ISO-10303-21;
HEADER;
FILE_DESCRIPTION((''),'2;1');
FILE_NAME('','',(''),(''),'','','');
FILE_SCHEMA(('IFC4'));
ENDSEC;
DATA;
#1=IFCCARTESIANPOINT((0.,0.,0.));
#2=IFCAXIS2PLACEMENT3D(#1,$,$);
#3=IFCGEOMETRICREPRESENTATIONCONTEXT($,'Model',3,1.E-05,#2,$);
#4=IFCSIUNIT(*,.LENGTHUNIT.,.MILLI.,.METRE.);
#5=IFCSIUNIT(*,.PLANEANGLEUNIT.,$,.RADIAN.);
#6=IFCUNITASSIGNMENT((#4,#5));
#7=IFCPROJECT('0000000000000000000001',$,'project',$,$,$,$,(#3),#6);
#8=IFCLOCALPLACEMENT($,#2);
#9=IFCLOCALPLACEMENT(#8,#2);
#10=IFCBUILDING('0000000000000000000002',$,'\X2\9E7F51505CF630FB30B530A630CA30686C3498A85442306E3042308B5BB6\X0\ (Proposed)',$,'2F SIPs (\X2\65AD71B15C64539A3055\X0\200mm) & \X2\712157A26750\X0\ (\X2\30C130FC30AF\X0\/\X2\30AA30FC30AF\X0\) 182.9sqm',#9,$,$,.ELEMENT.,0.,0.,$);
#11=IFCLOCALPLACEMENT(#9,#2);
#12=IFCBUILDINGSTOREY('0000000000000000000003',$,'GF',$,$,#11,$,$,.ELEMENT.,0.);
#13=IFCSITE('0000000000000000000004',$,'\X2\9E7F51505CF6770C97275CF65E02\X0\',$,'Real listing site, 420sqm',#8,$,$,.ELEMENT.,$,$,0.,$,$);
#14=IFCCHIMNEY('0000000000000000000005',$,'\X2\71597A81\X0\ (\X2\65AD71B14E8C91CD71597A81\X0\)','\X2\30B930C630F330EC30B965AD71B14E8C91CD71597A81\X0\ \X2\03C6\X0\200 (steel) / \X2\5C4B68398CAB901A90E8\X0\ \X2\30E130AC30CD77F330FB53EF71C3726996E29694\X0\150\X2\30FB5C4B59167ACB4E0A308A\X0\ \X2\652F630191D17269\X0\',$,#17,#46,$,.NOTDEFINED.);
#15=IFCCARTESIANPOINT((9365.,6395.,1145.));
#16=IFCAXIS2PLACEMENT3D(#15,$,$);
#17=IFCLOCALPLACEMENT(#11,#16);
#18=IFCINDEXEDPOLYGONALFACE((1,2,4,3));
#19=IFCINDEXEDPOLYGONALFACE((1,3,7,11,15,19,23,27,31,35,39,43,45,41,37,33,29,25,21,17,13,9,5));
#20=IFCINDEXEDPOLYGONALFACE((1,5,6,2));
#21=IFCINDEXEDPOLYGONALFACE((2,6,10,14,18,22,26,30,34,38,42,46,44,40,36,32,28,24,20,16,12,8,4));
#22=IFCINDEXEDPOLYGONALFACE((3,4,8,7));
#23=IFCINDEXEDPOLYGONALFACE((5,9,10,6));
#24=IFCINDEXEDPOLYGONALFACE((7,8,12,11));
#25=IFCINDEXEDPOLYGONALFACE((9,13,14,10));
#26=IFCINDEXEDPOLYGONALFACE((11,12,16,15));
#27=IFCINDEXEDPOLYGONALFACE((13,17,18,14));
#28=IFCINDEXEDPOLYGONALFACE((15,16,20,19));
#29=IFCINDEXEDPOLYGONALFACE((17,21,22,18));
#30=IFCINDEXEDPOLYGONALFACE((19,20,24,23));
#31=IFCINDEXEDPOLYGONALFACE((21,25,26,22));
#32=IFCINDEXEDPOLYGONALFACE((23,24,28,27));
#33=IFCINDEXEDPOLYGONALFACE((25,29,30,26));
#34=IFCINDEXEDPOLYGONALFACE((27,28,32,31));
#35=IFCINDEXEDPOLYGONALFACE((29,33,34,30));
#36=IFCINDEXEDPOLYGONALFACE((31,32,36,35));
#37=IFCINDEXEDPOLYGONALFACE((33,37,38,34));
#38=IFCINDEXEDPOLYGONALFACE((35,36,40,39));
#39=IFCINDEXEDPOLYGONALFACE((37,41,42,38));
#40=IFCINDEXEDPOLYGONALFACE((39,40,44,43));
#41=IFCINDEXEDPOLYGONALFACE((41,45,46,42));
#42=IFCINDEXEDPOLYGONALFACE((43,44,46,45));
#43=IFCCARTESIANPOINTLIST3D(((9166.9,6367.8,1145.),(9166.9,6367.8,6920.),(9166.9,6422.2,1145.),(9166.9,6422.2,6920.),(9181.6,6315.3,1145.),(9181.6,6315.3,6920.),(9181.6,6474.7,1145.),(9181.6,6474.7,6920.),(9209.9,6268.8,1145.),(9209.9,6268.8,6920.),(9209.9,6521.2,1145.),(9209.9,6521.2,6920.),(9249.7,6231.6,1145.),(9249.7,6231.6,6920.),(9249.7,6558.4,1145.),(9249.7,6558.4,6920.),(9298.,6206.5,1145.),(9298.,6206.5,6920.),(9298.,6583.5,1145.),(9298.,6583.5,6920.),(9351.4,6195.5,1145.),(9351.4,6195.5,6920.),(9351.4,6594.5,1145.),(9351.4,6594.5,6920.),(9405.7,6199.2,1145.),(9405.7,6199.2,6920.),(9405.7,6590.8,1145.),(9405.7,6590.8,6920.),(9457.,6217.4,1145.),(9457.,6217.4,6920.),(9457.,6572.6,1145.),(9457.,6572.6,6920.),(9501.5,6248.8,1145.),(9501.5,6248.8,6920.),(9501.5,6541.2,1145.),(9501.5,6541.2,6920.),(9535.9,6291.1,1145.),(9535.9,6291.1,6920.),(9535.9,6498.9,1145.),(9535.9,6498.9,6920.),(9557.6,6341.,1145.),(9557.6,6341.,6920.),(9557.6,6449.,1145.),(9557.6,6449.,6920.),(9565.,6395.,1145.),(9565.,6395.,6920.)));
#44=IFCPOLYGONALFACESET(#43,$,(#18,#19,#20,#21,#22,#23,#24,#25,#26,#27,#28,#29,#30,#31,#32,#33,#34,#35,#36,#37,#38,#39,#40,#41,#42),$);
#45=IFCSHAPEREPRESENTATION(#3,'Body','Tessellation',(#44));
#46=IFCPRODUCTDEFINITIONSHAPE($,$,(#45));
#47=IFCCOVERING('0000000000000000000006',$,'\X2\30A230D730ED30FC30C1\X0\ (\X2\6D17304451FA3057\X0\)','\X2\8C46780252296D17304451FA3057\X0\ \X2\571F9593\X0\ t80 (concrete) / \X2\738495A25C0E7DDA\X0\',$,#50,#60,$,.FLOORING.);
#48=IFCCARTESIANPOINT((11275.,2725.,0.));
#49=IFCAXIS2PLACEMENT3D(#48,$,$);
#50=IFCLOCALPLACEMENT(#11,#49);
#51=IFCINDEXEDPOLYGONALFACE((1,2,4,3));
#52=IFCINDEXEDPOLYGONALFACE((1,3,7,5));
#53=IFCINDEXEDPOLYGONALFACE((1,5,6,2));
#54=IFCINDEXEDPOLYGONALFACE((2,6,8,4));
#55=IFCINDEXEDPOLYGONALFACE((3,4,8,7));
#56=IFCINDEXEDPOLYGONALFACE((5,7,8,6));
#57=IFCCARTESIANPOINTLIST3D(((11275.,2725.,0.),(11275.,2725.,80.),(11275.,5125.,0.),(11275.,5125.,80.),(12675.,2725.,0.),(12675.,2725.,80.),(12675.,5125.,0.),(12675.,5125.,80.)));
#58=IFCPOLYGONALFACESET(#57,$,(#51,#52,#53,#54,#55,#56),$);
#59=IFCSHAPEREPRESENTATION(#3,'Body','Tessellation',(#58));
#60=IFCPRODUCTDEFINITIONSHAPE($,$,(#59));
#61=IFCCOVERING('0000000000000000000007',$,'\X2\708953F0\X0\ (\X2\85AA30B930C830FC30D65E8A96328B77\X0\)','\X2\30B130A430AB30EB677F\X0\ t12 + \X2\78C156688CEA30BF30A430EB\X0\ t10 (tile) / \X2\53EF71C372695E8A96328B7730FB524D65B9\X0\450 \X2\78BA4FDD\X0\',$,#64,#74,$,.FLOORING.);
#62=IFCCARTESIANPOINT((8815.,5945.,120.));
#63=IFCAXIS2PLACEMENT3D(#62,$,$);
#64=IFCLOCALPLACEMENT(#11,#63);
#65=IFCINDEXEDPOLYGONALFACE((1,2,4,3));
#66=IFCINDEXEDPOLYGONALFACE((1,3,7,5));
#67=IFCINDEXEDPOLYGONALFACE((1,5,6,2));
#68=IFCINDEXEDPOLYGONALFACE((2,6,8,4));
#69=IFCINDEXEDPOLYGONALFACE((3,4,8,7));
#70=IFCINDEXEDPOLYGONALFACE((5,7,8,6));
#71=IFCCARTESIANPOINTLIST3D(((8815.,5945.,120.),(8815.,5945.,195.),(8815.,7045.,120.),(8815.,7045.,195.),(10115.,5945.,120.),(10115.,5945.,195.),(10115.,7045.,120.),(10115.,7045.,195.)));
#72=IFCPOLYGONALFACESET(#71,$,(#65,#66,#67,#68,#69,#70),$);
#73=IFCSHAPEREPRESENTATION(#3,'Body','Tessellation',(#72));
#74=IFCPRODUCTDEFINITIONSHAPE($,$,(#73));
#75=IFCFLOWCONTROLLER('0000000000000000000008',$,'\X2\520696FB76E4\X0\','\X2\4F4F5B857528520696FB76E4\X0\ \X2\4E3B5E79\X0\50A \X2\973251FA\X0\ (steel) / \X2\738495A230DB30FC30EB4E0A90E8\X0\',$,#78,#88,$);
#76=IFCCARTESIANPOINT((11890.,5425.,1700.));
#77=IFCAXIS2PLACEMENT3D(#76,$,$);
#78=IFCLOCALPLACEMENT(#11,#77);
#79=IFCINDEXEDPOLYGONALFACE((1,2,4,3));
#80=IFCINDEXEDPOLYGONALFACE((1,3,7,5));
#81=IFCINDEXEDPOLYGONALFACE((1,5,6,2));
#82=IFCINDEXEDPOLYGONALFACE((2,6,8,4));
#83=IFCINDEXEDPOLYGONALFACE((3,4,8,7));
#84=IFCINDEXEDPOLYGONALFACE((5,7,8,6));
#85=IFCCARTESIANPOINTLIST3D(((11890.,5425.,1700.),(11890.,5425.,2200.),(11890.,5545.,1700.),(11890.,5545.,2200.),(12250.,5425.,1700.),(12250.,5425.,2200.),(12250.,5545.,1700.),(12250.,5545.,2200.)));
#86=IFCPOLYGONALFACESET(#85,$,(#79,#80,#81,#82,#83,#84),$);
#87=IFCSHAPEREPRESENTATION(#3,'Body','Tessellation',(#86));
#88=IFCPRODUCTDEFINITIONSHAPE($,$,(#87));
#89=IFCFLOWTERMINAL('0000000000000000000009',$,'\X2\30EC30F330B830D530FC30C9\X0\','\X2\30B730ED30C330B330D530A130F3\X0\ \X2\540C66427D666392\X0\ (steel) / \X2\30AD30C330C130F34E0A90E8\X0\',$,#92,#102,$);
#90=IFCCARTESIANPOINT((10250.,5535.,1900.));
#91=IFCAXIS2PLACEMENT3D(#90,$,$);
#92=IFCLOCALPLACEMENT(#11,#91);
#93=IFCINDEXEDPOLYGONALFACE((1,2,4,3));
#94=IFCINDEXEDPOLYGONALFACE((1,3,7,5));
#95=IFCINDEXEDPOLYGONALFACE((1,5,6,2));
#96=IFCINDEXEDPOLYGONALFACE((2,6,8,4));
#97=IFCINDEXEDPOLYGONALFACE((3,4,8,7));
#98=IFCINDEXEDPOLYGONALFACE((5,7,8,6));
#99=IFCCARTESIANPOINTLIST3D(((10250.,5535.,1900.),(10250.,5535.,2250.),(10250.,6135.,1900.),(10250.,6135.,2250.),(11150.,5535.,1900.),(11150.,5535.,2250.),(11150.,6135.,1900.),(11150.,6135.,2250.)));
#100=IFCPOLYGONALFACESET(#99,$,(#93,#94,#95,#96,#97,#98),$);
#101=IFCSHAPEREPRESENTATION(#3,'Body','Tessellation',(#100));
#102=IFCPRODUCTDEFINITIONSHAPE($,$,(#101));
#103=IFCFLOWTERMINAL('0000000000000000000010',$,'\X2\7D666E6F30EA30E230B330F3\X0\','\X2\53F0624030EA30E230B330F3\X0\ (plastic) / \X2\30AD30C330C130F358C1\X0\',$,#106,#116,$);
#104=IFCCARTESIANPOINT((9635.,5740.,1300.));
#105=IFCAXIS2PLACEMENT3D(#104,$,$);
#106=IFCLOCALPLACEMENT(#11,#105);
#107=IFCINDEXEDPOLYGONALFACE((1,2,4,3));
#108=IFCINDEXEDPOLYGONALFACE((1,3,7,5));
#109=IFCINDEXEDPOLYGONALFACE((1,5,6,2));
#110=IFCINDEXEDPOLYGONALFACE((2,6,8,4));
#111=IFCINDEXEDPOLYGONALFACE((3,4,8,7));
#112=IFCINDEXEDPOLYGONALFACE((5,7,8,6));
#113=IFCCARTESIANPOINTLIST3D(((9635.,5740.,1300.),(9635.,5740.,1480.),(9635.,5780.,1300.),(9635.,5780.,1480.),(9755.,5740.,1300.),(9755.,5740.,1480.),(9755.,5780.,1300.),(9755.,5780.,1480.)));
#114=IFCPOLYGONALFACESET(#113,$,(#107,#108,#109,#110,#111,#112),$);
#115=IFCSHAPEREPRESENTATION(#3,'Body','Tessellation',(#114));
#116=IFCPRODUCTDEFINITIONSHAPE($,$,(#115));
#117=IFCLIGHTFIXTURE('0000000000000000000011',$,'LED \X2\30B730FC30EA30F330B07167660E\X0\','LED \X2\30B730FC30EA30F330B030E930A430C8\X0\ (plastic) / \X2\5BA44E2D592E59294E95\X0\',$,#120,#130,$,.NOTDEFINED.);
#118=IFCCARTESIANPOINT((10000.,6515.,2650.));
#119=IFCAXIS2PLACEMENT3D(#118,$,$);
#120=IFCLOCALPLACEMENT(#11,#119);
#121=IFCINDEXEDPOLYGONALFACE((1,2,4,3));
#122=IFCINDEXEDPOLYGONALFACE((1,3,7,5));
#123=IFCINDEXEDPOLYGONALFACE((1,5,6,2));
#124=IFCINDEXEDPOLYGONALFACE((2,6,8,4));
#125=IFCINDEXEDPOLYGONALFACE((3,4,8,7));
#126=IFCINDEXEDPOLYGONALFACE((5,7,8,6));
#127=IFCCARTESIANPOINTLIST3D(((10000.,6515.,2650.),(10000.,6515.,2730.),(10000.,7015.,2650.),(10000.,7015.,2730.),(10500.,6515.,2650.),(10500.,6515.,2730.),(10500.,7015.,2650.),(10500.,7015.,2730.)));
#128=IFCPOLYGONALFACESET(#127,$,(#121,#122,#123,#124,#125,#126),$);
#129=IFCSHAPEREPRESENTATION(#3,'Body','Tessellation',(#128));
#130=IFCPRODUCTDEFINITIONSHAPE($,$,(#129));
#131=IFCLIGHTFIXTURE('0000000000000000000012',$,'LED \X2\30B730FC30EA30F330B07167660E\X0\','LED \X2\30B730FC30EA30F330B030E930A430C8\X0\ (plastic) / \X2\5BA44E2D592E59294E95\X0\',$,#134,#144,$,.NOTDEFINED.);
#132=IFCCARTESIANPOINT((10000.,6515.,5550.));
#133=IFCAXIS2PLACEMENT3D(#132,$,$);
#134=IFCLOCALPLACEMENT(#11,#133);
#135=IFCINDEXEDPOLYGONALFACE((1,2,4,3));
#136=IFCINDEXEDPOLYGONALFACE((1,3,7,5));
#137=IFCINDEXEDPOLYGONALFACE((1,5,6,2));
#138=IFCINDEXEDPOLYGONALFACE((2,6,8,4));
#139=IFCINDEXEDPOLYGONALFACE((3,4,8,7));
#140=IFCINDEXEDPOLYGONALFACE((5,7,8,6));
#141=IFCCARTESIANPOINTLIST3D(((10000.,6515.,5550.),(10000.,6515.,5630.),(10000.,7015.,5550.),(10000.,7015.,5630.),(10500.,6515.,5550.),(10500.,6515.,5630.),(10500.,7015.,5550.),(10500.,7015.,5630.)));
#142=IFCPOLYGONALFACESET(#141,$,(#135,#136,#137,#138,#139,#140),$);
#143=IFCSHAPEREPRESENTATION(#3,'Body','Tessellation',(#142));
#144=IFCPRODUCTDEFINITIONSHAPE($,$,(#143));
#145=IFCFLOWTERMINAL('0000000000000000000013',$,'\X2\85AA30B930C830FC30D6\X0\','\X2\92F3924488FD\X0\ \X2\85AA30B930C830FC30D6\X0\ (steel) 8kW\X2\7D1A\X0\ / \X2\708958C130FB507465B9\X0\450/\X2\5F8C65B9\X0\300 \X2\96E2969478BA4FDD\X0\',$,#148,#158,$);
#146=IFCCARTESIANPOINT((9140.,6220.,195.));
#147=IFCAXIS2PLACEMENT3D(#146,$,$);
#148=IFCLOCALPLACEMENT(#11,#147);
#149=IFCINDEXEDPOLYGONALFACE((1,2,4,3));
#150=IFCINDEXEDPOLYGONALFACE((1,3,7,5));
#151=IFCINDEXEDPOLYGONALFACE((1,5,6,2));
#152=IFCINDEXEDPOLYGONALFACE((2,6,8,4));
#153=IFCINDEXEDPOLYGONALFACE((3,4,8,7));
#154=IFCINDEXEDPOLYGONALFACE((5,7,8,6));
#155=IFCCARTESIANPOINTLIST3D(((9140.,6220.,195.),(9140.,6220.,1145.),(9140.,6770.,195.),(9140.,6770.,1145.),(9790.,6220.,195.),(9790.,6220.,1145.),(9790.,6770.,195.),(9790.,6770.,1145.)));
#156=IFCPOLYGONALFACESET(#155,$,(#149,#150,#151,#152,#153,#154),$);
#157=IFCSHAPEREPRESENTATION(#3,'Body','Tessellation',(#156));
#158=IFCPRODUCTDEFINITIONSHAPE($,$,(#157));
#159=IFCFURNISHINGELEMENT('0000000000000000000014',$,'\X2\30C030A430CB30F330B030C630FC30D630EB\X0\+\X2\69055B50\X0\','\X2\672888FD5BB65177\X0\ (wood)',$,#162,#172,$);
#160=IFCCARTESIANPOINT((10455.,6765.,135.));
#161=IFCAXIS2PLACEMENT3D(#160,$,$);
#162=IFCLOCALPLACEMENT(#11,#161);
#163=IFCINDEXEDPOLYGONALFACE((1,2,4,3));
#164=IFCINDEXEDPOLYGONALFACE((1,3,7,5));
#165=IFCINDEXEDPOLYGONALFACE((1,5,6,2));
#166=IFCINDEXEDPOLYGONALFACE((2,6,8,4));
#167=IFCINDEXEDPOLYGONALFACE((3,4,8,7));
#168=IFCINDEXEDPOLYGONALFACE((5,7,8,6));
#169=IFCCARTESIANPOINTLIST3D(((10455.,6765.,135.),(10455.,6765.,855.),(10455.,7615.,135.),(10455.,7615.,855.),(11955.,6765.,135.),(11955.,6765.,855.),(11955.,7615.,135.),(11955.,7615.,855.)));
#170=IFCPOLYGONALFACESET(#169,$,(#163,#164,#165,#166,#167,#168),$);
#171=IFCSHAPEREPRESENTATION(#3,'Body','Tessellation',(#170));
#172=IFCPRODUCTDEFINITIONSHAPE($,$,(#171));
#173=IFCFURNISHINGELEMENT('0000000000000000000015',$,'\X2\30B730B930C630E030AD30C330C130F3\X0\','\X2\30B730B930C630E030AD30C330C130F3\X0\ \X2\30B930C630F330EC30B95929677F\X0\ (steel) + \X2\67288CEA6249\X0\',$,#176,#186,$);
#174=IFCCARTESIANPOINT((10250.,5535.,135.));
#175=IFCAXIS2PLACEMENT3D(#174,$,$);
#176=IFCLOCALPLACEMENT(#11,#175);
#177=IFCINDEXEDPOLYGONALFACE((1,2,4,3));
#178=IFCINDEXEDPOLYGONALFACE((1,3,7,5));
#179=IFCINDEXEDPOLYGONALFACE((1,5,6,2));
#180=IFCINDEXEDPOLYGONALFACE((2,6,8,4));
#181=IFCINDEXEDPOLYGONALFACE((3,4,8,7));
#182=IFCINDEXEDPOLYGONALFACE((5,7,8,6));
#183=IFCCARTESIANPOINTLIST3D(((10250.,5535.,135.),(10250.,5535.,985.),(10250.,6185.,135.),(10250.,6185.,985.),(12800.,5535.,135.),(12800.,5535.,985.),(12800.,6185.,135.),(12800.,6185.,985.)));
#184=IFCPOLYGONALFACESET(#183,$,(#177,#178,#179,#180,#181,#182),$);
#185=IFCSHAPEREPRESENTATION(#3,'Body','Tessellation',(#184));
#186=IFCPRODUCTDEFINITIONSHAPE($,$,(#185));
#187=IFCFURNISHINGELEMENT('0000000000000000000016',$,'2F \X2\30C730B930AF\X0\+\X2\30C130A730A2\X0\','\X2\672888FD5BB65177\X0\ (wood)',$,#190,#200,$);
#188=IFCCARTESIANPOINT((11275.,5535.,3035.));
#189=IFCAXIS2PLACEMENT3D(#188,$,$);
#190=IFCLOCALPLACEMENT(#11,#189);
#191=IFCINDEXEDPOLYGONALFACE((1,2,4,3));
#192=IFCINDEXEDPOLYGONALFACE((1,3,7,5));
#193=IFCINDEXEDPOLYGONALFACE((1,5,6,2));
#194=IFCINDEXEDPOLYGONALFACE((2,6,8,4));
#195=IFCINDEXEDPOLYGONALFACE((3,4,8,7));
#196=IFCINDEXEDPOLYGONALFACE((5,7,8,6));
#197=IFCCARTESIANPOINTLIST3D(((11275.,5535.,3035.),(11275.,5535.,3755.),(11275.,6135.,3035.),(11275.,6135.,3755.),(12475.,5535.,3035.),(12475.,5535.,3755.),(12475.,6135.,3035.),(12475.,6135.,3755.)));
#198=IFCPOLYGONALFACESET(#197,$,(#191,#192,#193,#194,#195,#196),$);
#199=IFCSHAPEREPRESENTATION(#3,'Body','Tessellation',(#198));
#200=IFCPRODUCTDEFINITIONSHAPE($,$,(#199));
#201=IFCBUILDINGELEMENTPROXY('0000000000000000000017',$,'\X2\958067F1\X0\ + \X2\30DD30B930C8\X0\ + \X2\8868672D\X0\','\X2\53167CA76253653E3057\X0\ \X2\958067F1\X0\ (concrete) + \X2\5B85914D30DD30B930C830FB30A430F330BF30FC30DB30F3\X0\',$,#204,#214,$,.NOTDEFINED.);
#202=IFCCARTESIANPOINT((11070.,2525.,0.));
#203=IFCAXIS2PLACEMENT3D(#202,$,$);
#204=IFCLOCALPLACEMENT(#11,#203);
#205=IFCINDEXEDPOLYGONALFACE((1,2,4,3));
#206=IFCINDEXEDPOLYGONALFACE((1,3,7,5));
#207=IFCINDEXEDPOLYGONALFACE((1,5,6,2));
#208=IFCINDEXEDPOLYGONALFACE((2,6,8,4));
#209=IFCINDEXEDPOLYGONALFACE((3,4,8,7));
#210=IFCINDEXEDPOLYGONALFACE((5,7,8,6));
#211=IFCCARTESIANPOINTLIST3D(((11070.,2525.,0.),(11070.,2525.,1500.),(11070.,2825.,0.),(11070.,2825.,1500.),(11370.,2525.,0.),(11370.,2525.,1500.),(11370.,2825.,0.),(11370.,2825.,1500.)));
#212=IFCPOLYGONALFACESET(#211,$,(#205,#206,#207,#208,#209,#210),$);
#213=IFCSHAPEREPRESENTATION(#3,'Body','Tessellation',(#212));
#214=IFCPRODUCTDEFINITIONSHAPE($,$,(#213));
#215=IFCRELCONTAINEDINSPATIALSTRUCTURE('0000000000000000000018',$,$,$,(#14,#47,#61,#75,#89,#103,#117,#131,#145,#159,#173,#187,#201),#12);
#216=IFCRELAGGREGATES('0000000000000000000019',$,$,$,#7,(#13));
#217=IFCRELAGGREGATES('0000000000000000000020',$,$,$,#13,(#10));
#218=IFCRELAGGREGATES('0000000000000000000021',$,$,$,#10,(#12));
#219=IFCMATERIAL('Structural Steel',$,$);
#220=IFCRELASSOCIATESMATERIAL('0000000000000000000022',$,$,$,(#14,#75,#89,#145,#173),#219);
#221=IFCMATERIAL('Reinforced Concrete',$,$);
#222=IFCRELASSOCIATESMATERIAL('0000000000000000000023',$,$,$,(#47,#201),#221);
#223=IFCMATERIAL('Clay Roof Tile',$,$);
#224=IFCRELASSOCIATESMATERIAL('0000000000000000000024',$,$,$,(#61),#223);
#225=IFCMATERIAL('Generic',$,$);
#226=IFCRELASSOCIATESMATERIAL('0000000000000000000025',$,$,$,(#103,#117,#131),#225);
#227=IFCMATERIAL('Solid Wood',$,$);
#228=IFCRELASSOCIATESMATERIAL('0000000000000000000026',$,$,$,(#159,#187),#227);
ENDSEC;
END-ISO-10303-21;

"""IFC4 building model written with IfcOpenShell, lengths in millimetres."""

from ifc_helpers import new_model, si_unit, frame, frame_2d, origin, origin_2d, place, context, project, spatial, rectangle, circle, extrude, material, element, save


model = new_model("IFC4")

# Units and contexts
model_context = context("Model", 3, precision=1e-05, world=origin())
ifc_project = project(units=[si_unit("LENGTHUNIT", "METRE", prefix="MILLI"), si_unit("PLANEANGLEUNIT", "RADIAN")], contexts=[model_context])

# Site, building, storey
site_placement = place(None, origin())
site = spatial("IfcSite", under=ifc_project, at=site_placement, Name="鹿児島県霧島市", ObjectType="Real listing site, 420sqm", CompositionType="ELEMENT", RefElevation=0.0)
building_placement = place(site_placement, origin())
building = spatial("IfcBuilding", under=site, at=building_placement, Name="鹿児島・サウナと水風呂のある家 (Proposed)", ObjectType="2F SIPs (断熱層厚さ200mm) & 無垢材 (チーク/オーク) 182.9sqm", CompositionType="ELEMENT", ElevationOfRefHeight=0.0, ElevationOfTerrain=0.0)
storey_placement = place(building_placement, origin())
storey = spatial("IfcBuildingStorey", under=building, at=storey_placement, Name="GF", CompositionType="ELEMENT", Elevation=0.0)

# Shared definitions
ifc_material_1 = material(Name="Solid Wood")

# Shared definitions
ifc_material_2 = material(Name="Structural Steel")

# Chimney
chimney_placement = place(storey_placement, frame((9365.0, 6395.0, 1145.0)))
element("IfcChimney", 1, at=chimney_placement, inside=storey, material=ifc_material_2, Name="煙突 (断熱二重煙突)", Description="ステンレス断熱二重煙突 φ200 (steel) / 屋根貫通部 メガネ石・可燃物離隔150・屋外立上り 支持金物", PredefinedType="NOTDEFINED", context=model_context, shape_type="SweptSolid", body=[
    extrude(circle(Radius=200.0, at=origin_2d()), frame((9365.0, 6395.0, 1145.0)), (0.0, 0.0, 1.0), 5775.0),
])

# Coverings
ifc_material_3 = material(Name="Reinforced Concrete")
covering_1_placement = place(storey_placement, frame((11275.0, 2725.0, 0.0)))
element("IfcCovering", 2, at=covering_1_placement, inside=storey, material=ifc_material_3, Name="アプローチ (洗い出し)", Description="豆砂利洗い出し 土間 t80 (concrete) / 玄関導線", PredefinedType="FLOORING", context=model_context, shape_type="SweptSolid", body=[
    extrude(rectangle(XDim=1400.0, YDim=2400.0, at=frame_2d((700.0, 1200.0))), frame((11275.0, 2725.0, 0.0)), (0.0, 0.0, 1.0), 80.0),
])
ifc_material_4 = material(Name="Clay Roof Tile")
covering_2_placement = place(storey_placement, frame((8815.0, 5945.0, 120.0)))
element("IfcCovering", 3, at=covering_2_placement, inside=storey, material=ifc_material_4, Name="炉台 (薪ストーブ床防護)", Description="ケイカル板 t12 + 磁器質タイル t10 (tile) / 可燃物床防護・前方450 確保", PredefinedType="FLOORING", context=model_context, shape_type="SweptSolid", body=[
    extrude(rectangle(XDim=1300.0, YDim=1100.0, at=frame_2d((650.0, 550.0))), frame((8815.0, 5945.0, 120.0)), (0.0, 0.0, 1.0), 75.0),
])

# Flow controller
flow_controller_placement = place(storey_placement, frame((11890.0, 5425.0, 1700.0)))
element("IfcFlowController", 4, at=flow_controller_placement, inside=storey, material=ifc_material_2, Name="分電盤", Description="住宅用分電盤 主幹50A 露出 (steel) / 玄関ホール上部", context=model_context, shape_type="SweptSolid", body=[
    extrude(rectangle(XDim=360.0, YDim=120.0, at=frame_2d((180.0, 60.0))), frame((11890.0, 5425.0, 1700.0)), (0.0, 0.0, 1.0), 500.0),
])

# Flow terminals
flow_terminal_1_placement = place(storey_placement, frame((10250.0, 5535.0, 1900.0)))
element("IfcFlowTerminal", 5, at=flow_terminal_1_placement, inside=storey, material=ifc_material_2, Name="レンジフード", Description="シロッコファン 同時給排 (steel) / キッチン上部", context=model_context, shape_type="SweptSolid", body=[
    extrude(rectangle(XDim=900.0, YDim=600.0, at=frame_2d((450.0, 300.0))), frame((10250.0, 5535.0, 1900.0)), (0.0, 0.0, 1.0), 350.0),
])
ifc_material_5 = material(Name="Generic")
flow_terminal_2_placement = place(storey_placement, frame((9635.0, 5740.0, 1300.0)))
element("IfcFlowTerminal", 6, at=flow_terminal_2_placement, inside=storey, material=ifc_material_5, Name="給湯リモコン", Description="台所リモコン (plastic) / キッチン壁", context=model_context, shape_type="SweptSolid", body=[
    extrude(rectangle(XDim=120.0, YDim=40.0, at=frame_2d((60.0, 20.0))), frame((9635.0, 5740.0, 1300.0)), (0.0, 0.0, 1.0), 180.0),
])

# Light fixtures
light_fixture_1_placement = place(storey_placement, frame((10000.0, 6515.0, 2650.0)))
element("IfcLightFixture", 7, at=light_fixture_1_placement, inside=storey, material=ifc_material_5, Name="LED シーリング照明", Description="LED シーリングライト (plastic) / 室中央天井", PredefinedType="NOTDEFINED", context=model_context, shape_type="SweptSolid", body=[
    extrude(rectangle(XDim=500.0, YDim=500.0, at=frame_2d((250.0, 250.0))), frame((10000.0, 6515.0, 2650.0)), (0.0, 0.0, 1.0), 80.0),
])
light_fixture_2_placement = place(storey_placement, frame((10000.0, 6515.0, 5550.0)))
element("IfcLightFixture", 8, at=light_fixture_2_placement, inside=storey, material=ifc_material_5, Name="LED シーリング照明", Description="LED シーリングライト (plastic) / 室中央天井", PredefinedType="NOTDEFINED", context=model_context, shape_type="SweptSolid", body=[
    extrude(rectangle(XDim=500.0, YDim=500.0, at=frame_2d((250.0, 250.0))), frame((10000.0, 6515.0, 5550.0)), (0.0, 0.0, 1.0), 80.0),
])

# Flow terminal
flow_terminal_3_placement = place(storey_placement, frame((9140.0, 6220.0, 195.0)))
element("IfcFlowTerminal", 9, at=flow_terminal_3_placement, inside=storey, material=ifc_material_2, Name="薪ストーブ", Description="鋳鉄製 薪ストーブ (steel) 8kW級 / 炉壁・側方450/後方300 離隔確保", context=model_context, shape_type="SweptSolid", body=[
    extrude(rectangle(XDim=650.0, YDim=550.0, at=frame_2d((325.0, 275.0))), frame((9140.0, 6220.0, 195.0)), (0.0, 0.0, 1.0), 950.0),
])

# Furnishing elements
furnishing_1_placement = place(storey_placement, frame((10455.0, 6765.0, 135.0)))
element("IfcFurnishingElement", 10, at=furnishing_1_placement, inside=storey, material=ifc_material_1, Name="ダイニングテーブル+椅子", Description="木製家具 (wood)", context=model_context, shape_type="SweptSolid", body=[
    extrude(rectangle(XDim=1500.0, YDim=850.0, at=frame_2d((750.0, 425.0))), frame((10455.0, 6765.0, 135.0)), (0.0, 0.0, 1.0), 720.0),
])
furnishing_2_placement = place(storey_placement, frame((10250.0, 5535.0, 135.0)))
element("IfcFurnishingElement", 11, at=furnishing_2_placement, inside=storey, material=ifc_material_2, Name="システムキッチン", Description="システムキッチン ステンレス天板 (steel) + 木質扉", context=model_context, shape_type="SweptSolid", body=[
    extrude(rectangle(XDim=2550.0, YDim=650.0, at=frame_2d((1275.0, 325.0))), frame((10250.0, 5535.0, 135.0)), (0.0, 0.0, 1.0), 850.0),
])
furnishing_3_placement = place(storey_placement, frame((11275.0, 5535.0, 3035.0)))
element("IfcFurnishingElement", 12, at=furnishing_3_placement, inside=storey, material=ifc_material_1, Name="2F デスク+チェア", Description="木製家具 (wood)", context=model_context, shape_type="SweptSolid", body=[
    extrude(rectangle(XDim=1200.0, YDim=600.0, at=frame_2d((600.0, 300.0))), frame((11275.0, 5535.0, 3035.0)), (0.0, 0.0, 1.0), 720.0),
])

# Building element proxy
proxy_placement = place(storey_placement, frame((11070.0, 2525.0, 0.0)))
element("IfcBuildingElementProxy", 13, at=proxy_placement, inside=storey, material=ifc_material_3, Name="門柱 + ポスト + 表札", Description="化粧打放し 門柱 (concrete) + 宅配ポスト・インターホン", PredefinedType="NOTDEFINED", context=model_context, shape_type="SweptSolid", body=[
    extrude(rectangle(XDim=300.0, YDim=300.0, at=frame_2d((150.0, 150.0))), frame((11070.0, 2525.0, 0.0)), (0.0, 0.0, 1.0), 1500.0),
])

save(model, "model.ifc")
